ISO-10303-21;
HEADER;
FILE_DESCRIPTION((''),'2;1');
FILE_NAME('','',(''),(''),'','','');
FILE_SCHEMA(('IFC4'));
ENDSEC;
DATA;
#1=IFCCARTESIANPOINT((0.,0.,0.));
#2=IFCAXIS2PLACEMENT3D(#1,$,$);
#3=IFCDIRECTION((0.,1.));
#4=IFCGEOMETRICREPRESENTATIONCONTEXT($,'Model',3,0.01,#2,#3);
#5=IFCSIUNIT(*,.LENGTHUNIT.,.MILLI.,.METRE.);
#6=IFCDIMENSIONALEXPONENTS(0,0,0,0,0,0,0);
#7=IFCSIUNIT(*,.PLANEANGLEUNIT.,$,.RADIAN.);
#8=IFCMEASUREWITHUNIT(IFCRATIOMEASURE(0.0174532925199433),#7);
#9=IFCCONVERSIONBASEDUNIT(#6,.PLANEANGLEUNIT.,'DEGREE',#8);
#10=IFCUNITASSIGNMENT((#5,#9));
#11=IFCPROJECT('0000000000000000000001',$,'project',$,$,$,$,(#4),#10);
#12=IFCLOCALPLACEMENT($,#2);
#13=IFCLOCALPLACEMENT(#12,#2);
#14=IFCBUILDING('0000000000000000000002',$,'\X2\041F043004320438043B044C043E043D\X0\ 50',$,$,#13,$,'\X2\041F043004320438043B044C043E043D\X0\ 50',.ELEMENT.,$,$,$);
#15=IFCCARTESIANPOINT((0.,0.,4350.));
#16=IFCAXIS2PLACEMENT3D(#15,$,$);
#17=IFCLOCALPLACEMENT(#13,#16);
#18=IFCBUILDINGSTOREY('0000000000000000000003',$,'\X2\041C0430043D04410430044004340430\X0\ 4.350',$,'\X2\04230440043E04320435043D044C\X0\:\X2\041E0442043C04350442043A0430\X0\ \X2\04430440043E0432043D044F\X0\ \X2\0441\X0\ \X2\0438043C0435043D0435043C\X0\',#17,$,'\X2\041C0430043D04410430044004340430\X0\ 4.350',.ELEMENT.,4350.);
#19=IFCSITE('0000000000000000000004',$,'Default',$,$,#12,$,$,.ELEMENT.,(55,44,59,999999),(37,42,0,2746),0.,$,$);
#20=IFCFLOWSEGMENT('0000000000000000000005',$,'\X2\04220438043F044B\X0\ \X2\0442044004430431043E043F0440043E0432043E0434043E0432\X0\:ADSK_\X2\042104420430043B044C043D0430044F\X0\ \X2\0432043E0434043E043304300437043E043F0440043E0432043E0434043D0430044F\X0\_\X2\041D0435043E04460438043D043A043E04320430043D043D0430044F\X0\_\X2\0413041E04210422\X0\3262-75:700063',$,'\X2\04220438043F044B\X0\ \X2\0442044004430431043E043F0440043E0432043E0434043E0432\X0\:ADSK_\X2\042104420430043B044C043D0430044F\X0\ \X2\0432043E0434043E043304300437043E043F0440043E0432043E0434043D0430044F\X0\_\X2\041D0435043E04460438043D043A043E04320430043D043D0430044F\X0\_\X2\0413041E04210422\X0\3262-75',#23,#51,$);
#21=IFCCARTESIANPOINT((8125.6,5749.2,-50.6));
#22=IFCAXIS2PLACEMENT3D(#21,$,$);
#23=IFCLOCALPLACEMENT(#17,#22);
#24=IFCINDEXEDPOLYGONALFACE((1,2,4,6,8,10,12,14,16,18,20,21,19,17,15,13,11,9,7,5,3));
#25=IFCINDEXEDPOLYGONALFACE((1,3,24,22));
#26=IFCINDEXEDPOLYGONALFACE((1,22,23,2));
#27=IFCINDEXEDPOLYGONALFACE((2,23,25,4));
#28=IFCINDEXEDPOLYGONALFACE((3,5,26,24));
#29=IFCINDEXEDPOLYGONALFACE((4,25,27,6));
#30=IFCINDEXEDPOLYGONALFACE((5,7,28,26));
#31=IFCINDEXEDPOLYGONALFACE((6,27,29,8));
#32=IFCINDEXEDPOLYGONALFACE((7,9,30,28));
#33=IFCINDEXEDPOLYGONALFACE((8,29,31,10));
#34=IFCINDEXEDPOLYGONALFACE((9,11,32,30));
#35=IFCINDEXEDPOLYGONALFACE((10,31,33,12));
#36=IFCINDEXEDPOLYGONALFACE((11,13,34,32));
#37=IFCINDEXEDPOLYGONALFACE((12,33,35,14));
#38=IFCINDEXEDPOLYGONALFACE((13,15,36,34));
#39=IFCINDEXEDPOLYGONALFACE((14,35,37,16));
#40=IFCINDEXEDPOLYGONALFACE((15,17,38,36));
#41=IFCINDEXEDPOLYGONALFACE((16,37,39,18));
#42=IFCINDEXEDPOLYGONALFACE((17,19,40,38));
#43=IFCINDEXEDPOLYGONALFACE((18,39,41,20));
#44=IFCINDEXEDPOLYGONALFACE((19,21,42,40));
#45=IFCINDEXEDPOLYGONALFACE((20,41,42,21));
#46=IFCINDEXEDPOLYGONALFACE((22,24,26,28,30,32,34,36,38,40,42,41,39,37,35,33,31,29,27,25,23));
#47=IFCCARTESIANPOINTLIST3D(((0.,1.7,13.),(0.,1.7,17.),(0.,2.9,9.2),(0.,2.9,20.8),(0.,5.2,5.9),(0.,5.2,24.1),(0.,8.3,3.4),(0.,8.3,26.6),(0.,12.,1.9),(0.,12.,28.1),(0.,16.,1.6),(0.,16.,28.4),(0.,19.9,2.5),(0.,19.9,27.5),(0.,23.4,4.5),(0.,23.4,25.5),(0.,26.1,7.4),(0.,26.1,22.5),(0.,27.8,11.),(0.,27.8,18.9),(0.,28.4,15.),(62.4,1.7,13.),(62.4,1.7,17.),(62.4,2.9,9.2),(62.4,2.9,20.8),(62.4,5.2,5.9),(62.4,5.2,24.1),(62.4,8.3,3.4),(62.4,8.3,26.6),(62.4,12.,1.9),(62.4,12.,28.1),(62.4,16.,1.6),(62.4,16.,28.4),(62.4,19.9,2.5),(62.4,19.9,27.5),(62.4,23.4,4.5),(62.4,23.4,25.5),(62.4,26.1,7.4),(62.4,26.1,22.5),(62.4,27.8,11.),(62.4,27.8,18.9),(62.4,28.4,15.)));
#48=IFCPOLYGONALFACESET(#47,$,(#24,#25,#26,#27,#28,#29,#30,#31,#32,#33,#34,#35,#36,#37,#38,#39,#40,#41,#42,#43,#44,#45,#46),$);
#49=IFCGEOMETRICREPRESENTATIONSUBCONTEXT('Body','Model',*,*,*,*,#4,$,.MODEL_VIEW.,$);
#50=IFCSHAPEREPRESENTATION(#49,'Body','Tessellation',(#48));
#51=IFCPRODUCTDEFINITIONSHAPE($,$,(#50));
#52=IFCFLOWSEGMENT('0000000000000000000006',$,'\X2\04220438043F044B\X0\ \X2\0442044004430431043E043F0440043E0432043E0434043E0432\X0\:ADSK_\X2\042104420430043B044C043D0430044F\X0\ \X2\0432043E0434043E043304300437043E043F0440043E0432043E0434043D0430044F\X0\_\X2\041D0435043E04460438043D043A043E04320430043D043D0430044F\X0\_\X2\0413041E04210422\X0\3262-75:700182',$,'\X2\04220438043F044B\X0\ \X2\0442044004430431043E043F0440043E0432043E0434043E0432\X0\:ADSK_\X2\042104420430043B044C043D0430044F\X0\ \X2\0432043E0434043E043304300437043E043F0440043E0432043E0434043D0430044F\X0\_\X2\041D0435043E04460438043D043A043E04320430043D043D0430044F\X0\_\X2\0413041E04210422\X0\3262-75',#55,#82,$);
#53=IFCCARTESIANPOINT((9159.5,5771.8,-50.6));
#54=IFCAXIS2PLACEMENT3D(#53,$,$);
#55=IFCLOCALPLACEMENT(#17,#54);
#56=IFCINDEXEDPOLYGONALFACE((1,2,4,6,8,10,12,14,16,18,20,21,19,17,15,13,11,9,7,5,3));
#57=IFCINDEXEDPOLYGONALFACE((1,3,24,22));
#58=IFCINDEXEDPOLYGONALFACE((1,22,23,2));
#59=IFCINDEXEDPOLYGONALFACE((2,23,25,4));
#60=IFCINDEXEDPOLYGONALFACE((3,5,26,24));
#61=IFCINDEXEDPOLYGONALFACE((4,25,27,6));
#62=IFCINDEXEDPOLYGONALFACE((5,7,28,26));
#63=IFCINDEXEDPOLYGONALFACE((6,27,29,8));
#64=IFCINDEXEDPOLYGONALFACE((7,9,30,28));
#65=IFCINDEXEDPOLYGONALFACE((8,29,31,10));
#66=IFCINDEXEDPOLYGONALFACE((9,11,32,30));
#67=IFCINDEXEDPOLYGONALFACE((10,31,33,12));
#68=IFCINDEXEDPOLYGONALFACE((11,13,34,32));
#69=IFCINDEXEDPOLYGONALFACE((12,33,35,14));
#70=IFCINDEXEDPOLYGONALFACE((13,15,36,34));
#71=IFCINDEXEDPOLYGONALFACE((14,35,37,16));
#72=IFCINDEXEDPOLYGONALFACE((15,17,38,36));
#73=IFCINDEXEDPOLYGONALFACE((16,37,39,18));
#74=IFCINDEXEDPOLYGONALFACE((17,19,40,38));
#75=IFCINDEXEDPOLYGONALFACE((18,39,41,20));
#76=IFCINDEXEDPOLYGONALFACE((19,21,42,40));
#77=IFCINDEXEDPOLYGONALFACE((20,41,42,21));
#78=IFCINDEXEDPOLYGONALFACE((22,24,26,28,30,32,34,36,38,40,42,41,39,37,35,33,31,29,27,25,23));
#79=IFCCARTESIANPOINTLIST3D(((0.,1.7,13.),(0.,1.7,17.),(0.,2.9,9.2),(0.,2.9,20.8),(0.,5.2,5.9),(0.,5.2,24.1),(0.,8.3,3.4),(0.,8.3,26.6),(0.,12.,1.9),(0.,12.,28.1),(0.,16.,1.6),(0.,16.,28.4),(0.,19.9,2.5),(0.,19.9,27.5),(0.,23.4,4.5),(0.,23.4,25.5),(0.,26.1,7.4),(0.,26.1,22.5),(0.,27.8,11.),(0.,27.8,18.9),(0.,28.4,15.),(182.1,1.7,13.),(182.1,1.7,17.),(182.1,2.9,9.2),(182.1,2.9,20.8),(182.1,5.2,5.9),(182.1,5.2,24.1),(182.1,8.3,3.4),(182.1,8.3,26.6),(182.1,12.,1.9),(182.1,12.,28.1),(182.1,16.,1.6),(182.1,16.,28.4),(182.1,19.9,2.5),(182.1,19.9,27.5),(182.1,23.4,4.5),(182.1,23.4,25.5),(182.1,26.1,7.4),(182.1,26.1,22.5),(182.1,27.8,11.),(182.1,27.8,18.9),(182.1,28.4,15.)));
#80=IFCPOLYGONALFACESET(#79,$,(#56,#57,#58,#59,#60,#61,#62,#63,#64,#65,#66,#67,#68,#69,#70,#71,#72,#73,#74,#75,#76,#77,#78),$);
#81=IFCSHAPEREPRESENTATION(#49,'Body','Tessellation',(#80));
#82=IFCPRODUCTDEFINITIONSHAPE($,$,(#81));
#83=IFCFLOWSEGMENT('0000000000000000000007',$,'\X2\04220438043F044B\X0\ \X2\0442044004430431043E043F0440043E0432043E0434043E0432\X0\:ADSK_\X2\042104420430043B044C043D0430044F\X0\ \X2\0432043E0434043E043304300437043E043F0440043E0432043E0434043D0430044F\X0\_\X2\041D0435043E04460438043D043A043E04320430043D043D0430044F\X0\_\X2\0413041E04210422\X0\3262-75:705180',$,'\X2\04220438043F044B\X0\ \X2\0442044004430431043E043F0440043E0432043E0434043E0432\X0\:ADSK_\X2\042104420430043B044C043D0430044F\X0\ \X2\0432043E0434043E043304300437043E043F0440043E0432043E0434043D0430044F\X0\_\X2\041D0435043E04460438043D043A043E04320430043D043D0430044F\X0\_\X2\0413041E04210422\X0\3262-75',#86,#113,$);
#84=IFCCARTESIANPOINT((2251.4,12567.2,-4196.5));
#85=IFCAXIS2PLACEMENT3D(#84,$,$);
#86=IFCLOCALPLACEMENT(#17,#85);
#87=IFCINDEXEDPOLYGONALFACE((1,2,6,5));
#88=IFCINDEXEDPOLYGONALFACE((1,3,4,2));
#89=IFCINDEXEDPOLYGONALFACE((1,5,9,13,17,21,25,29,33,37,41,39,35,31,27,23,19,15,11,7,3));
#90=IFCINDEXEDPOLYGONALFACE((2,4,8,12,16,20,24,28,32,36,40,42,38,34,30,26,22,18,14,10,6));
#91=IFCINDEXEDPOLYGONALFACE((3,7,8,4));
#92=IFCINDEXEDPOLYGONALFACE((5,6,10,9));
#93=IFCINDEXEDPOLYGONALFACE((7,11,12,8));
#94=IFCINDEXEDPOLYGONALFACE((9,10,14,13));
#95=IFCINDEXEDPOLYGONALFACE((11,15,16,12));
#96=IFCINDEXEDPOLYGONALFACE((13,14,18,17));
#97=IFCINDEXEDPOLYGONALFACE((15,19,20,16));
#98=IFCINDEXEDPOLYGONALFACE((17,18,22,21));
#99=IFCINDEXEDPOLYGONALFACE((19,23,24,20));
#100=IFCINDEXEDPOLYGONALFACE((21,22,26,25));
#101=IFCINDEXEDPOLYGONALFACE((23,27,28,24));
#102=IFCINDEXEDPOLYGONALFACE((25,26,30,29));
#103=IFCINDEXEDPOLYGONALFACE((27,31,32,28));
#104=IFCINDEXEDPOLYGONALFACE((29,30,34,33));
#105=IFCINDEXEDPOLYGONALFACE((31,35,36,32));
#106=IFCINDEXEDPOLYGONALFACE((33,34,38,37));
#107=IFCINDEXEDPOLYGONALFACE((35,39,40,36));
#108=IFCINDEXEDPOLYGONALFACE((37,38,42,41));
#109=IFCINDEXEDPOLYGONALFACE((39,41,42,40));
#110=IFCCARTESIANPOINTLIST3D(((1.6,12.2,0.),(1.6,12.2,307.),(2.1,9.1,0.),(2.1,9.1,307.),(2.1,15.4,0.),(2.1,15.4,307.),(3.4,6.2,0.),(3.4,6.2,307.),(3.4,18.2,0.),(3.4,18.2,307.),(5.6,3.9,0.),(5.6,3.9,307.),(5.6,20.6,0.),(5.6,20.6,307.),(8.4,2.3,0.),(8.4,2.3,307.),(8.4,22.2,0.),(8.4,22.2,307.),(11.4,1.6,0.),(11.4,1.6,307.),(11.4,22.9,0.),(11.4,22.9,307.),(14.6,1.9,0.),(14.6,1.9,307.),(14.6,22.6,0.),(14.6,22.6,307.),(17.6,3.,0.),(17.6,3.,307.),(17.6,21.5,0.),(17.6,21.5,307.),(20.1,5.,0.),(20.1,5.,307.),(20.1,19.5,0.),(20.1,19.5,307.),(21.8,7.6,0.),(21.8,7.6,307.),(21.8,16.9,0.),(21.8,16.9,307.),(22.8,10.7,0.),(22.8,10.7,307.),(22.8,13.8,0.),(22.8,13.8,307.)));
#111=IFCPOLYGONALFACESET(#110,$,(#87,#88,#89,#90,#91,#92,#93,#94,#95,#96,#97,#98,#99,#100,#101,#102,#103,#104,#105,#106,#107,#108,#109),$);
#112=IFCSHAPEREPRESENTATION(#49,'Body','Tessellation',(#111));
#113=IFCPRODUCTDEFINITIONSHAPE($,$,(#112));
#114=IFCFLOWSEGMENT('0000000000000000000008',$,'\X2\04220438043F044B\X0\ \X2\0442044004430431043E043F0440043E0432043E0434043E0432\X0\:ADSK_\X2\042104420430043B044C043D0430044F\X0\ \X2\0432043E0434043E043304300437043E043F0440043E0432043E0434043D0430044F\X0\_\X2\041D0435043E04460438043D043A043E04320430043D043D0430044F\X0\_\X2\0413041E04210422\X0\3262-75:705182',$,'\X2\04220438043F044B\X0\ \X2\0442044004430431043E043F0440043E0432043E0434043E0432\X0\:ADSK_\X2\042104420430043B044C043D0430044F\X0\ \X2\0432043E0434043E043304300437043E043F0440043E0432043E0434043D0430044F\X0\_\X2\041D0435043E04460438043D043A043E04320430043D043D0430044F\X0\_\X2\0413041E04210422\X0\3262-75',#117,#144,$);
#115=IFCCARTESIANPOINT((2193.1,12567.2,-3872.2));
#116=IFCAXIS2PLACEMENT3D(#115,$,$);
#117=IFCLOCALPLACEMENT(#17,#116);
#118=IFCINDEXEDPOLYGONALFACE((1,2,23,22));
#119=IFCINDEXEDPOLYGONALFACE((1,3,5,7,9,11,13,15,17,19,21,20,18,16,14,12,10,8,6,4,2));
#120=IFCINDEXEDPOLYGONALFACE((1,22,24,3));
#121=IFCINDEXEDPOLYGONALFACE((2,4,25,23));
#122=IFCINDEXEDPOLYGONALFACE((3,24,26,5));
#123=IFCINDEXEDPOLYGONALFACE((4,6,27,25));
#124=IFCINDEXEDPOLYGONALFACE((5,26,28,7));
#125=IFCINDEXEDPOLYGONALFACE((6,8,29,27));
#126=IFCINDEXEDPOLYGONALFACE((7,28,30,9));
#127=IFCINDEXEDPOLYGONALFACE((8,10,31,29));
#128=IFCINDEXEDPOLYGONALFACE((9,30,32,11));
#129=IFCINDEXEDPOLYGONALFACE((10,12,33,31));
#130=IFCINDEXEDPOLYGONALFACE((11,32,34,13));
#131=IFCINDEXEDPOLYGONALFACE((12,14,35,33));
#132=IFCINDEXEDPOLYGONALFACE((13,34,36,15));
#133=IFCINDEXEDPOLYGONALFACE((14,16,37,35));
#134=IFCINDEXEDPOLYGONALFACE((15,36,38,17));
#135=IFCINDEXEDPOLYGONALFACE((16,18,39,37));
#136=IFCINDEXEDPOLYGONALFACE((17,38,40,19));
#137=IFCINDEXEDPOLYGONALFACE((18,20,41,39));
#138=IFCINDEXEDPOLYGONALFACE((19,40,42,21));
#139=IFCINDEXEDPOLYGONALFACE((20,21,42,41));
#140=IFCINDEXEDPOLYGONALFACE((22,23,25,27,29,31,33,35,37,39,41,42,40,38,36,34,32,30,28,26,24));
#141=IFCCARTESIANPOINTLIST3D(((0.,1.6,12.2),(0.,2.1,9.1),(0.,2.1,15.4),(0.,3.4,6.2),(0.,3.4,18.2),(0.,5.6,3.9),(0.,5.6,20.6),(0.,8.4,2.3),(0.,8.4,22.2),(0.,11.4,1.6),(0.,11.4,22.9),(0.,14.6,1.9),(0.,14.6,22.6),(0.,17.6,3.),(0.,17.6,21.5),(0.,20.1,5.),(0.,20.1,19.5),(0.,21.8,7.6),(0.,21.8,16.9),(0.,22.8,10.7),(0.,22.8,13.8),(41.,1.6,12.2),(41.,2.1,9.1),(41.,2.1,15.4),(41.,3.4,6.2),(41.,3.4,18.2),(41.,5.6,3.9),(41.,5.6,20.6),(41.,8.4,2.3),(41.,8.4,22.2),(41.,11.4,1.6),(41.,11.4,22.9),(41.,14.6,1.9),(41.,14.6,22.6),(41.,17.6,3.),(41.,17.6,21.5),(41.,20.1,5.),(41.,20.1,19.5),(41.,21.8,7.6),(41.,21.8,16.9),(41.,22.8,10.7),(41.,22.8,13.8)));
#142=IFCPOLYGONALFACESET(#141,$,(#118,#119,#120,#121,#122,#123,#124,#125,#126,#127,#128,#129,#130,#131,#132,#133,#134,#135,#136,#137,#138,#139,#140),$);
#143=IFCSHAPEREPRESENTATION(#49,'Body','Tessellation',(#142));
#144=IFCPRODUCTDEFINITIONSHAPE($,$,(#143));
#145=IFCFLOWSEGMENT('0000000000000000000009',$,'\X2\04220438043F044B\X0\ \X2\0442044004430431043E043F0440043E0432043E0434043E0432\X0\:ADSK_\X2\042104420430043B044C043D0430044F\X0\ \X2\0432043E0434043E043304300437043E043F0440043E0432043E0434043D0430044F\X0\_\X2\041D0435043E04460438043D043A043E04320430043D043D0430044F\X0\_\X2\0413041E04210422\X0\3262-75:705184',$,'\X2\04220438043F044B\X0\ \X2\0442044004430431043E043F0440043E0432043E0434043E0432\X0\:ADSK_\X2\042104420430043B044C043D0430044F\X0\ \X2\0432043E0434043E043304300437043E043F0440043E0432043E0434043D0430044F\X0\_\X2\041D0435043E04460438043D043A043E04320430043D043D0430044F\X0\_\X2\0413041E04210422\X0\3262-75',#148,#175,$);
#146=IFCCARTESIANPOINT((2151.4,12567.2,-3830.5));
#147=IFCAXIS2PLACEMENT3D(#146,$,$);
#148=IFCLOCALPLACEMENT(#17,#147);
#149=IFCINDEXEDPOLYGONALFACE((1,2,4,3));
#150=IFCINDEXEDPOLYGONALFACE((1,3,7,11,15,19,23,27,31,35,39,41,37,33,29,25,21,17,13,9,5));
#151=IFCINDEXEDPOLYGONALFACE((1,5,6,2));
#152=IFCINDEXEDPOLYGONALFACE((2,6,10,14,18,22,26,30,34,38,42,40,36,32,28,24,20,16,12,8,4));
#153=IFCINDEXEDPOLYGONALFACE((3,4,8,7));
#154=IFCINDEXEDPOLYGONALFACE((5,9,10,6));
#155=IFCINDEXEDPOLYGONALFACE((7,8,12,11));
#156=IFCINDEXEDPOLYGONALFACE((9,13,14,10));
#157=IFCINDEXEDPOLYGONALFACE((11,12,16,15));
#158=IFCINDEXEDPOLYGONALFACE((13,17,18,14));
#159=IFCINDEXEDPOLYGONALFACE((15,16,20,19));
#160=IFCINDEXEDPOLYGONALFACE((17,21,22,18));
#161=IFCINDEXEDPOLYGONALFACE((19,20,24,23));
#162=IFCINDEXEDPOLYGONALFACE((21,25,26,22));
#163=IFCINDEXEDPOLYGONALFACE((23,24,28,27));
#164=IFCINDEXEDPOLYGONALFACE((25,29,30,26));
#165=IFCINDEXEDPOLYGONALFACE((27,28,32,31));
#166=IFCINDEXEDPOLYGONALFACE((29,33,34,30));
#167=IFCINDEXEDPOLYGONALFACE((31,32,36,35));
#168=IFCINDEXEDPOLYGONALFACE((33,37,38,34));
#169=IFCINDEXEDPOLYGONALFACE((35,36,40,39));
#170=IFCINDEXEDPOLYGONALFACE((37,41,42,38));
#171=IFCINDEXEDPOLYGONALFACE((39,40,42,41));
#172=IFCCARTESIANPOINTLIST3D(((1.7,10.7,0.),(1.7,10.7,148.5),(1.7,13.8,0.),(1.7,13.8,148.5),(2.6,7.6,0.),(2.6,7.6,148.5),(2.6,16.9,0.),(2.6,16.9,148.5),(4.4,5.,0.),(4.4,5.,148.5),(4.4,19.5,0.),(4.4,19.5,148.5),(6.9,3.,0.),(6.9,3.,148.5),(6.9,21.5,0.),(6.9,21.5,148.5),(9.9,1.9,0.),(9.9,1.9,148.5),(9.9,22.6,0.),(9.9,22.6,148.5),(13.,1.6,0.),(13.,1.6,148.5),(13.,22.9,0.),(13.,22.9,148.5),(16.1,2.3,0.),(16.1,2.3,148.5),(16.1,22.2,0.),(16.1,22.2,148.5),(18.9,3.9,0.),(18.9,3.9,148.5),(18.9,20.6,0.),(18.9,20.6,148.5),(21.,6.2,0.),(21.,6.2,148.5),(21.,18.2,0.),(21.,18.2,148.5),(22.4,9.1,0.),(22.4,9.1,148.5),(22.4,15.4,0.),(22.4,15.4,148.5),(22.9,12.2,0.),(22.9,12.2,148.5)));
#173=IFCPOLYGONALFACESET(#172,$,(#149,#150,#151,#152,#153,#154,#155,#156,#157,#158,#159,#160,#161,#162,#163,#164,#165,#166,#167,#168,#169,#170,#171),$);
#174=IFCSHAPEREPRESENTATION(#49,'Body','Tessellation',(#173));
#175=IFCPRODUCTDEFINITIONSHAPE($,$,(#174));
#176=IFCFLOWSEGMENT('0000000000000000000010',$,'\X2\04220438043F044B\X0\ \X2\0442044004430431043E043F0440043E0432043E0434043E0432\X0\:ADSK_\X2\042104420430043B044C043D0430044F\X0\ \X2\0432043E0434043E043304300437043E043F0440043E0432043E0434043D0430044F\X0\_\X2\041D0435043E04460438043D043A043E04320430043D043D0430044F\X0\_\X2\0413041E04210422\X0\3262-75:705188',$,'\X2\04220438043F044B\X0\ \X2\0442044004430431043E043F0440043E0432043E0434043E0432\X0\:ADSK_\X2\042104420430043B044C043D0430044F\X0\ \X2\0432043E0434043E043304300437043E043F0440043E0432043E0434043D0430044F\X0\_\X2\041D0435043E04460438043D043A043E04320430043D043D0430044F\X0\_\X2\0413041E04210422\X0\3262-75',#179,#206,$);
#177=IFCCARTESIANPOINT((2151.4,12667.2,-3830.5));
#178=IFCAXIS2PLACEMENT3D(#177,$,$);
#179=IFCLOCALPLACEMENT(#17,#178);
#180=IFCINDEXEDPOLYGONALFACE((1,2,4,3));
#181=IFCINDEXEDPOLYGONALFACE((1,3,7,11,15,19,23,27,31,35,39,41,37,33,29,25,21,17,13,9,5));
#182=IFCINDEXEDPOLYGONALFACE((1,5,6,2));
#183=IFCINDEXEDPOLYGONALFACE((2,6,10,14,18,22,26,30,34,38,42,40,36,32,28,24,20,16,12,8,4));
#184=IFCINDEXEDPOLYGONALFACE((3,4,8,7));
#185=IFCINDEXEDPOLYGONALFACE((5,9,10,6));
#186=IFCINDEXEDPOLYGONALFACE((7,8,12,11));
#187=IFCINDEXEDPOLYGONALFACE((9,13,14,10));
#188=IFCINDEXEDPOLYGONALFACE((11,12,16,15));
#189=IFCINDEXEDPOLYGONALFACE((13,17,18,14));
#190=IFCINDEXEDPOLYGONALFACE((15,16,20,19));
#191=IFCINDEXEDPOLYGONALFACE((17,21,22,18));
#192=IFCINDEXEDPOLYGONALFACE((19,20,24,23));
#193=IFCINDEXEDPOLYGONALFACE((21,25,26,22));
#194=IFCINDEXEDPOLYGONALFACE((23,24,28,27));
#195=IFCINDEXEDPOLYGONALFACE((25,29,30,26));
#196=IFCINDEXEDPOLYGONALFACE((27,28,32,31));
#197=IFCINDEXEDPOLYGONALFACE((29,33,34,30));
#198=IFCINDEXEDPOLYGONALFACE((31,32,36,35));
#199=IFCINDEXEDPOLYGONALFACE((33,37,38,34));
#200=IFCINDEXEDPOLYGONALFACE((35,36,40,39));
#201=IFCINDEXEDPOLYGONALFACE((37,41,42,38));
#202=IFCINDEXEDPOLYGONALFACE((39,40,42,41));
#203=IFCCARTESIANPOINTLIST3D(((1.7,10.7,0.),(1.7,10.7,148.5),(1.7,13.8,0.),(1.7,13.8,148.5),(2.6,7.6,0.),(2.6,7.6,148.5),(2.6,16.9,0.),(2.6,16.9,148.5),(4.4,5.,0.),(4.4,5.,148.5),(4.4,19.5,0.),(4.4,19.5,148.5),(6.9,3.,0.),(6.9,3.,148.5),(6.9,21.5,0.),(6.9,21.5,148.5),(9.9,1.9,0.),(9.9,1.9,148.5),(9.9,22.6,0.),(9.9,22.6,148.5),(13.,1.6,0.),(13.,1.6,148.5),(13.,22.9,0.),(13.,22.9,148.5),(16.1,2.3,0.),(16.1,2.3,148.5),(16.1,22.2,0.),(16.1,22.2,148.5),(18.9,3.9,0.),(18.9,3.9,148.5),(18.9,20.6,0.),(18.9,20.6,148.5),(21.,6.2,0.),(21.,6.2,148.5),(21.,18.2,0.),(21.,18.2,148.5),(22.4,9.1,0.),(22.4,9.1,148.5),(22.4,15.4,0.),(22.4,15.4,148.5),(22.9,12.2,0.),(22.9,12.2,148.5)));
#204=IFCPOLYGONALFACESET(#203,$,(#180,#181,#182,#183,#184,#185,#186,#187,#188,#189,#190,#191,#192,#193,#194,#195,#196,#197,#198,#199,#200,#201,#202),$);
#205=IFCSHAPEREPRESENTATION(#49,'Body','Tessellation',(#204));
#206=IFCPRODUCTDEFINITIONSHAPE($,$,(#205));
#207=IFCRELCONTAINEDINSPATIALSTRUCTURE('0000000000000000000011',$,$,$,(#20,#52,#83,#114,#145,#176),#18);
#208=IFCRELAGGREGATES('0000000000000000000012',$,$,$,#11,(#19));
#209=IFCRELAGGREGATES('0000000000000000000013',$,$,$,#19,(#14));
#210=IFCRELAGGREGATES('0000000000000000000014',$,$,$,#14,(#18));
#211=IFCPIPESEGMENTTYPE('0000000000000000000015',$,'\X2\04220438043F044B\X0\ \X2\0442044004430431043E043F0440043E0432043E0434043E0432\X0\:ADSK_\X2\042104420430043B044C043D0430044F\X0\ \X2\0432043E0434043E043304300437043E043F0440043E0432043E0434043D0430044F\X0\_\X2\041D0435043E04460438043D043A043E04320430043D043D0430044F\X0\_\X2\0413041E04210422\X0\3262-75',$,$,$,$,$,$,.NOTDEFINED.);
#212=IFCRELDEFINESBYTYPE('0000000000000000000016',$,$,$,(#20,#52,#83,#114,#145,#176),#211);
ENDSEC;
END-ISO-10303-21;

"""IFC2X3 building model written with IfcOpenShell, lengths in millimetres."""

from ifc_helpers import new_model, entity, si_unit, converted_unit, direction, frame, origin, origin_2d_with_axis, place, context, subcontext, project, spatial, circle, extrude, type_object, element, save


model = new_model("IFC2X3")

# Units and contexts
model_context = context("Model", 3, precision=0.01, world=origin(), true_north=direction((0.0, 1.0)))
body_context = subcontext(model_context, "Body", "Model", "MODEL_VIEW")
ifc_project = project(units=[si_unit("LENGTHUNIT", "METRE", prefix="MILLI"), converted_unit("PLANEANGLEUNIT", "DEGREE", entity("IfcRatioMeasure", 0.0174532925199433), si_unit("PLANEANGLEUNIT", "RADIAN"), dimensions=[0, 0, 0, 0, 0, 0, 0])], contexts=[model_context])

# Site, building, storey
site_placement = place(None, origin())
site = spatial("IfcSite", under=ifc_project, at=site_placement, Name="Default", CompositionType="ELEMENT", RefLatitude=(55, 44, 59, 999999), RefLongitude=(37, 42, 0, 2746), RefElevation=0.0)
building_placement = place(site_placement, origin())
building = spatial("IfcBuilding", under=site, at=building_placement, Name="Павильон 50", LongName="Павильон 50", CompositionType="ELEMENT")
storey_placement = place(building_placement, frame((0.0, 0.0, 4350.0)))
storey = spatial("IfcBuildingStorey", under=building, at=storey_placement, Name="Мансарда 4.350", ObjectType="Уровень:Отметка уровня с именем", LongName="Мансарда 4.350", CompositionType="ELEMENT", Elevation=4350.0)

# Flow segments
pipe_segment_type = type_object("IfcPipeSegmentType", Name="Типы трубопроводов:ADSK_Стальная водогазопроводная_Неоцинкованная_ГОСТ3262-75", PredefinedType="NOTDEFINED")
flow_segment_1_placement = place(storey_placement, frame((8125.6, 5749.2, -50.6)))
element("IfcFlowSegment", 1, at=flow_segment_1_placement, inside=storey, type_object=pipe_segment_type, Name="Типы трубопроводов:ADSK_Стальная водогазопроводная_Неоцинкованная_ГОСТ3262-75:700063", ObjectType="Типы трубопроводов:ADSK_Стальная водогазопроводная_Неоцинкованная_ГОСТ3262-75", context=body_context, shape_type="SweptSolid", body=[
    extrude(circle(Radius=13.4, at=origin_2d_with_axis()), frame((0.0, 15.0, 15.0), z_axis=(1.0, 0.0, 0.0), x_axis=(0.0, 1.0, 0.0)), (0.0, 0.0, 1.0), 62.4),
])
flow_segment_2_placement = place(storey_placement, frame((9159.5, 5771.8, -50.6)))
element("IfcFlowSegment", 2, at=flow_segment_2_placement, inside=storey, type_object=pipe_segment_type, Name="Типы трубопроводов:ADSK_Стальная водогазопроводная_Неоцинкованная_ГОСТ3262-75:700182", ObjectType="Типы трубопроводов:ADSK_Стальная водогазопроводная_Неоцинкованная_ГОСТ3262-75", context=body_context, shape_type="SweptSolid", body=[
    extrude(circle(Radius=13.4, at=origin_2d_with_axis()), frame((0.0, 15.0, 15.0), z_axis=(1.0, 0.0, 0.0), x_axis=(0.0, 1.0, 0.0)), (0.0, 0.0, 1.0), 182.1),
])
flow_segment_3_placement = place(storey_placement, frame((2251.4, 12567.2, -4196.5)))
element("IfcFlowSegment", 3, at=flow_segment_3_placement, inside=storey, type_object=pipe_segment_type, Name="Типы трубопроводов:ADSK_Стальная водогазопроводная_Неоцинкованная_ГОСТ3262-75:705180", ObjectType="Типы трубопроводов:ADSK_Стальная водогазопроводная_Неоцинкованная_ГОСТ3262-75", context=body_context, shape_type="SweptSolid", body=[
    extrude(circle(Radius=10.7, at=origin_2d_with_axis()), frame((12.2, 12.2, 0.0), z_axis=(0.0, 0.0, 1.0), x_axis=(-1.0, 0.0, 0.0)), (0.0, 0.0, 1.0), 307.0),
])
flow_segment_4_placement = place(storey_placement, frame((2193.1, 12567.2, -3872.2)))
element("IfcFlowSegment", 4, at=flow_segment_4_placement, inside=storey, type_object=pipe_segment_type, Name="Типы трубопроводов:ADSK_Стальная водогазопроводная_Неоцинкованная_ГОСТ3262-75:705182", ObjectType="Типы трубопроводов:ADSK_Стальная водогазопроводная_Неоцинкованная_ГОСТ3262-75", context=body_context, shape_type="SweptSolid", body=[
    extrude(circle(Radius=10.7, at=origin_2d_with_axis()), frame((0.0, 12.2, 12.2), z_axis=(1.0, 0.0, 0.0), x_axis=(0.0, -1.0, 0.0)), (0.0, 0.0, 1.0), 41.0),
])
for number, where, name in (
    (5, (2151.4, 12567.2, -3830.5), "Типы трубопроводов:ADSK_Стальная водогазопроводная_Неоцинкованная_ГОСТ3262-75:705184"),
    (6, (2151.4, 12667.2, -3830.5), "Типы трубопроводов:ADSK_Стальная водогазопроводная_Неоцинкованная_ГОСТ3262-75:705188"),
):
    element("IfcFlowSegment", number, at=place(storey_placement, frame(where)), inside=storey, type_object=pipe_segment_type, Name=name, ObjectType="Типы трубопроводов:ADSK_Стальная водогазопроводная_Неоцинкованная_ГОСТ3262-75", context=body_context, shape_type="SweptSolid", body=[
        extrude(circle(Radius=10.7, at=origin_2d_with_axis()), frame((12.2, 12.2, 0.0)), (0.0, 0.0, 1.0), 148.5),
    ])

save(model, "model.ifc")
